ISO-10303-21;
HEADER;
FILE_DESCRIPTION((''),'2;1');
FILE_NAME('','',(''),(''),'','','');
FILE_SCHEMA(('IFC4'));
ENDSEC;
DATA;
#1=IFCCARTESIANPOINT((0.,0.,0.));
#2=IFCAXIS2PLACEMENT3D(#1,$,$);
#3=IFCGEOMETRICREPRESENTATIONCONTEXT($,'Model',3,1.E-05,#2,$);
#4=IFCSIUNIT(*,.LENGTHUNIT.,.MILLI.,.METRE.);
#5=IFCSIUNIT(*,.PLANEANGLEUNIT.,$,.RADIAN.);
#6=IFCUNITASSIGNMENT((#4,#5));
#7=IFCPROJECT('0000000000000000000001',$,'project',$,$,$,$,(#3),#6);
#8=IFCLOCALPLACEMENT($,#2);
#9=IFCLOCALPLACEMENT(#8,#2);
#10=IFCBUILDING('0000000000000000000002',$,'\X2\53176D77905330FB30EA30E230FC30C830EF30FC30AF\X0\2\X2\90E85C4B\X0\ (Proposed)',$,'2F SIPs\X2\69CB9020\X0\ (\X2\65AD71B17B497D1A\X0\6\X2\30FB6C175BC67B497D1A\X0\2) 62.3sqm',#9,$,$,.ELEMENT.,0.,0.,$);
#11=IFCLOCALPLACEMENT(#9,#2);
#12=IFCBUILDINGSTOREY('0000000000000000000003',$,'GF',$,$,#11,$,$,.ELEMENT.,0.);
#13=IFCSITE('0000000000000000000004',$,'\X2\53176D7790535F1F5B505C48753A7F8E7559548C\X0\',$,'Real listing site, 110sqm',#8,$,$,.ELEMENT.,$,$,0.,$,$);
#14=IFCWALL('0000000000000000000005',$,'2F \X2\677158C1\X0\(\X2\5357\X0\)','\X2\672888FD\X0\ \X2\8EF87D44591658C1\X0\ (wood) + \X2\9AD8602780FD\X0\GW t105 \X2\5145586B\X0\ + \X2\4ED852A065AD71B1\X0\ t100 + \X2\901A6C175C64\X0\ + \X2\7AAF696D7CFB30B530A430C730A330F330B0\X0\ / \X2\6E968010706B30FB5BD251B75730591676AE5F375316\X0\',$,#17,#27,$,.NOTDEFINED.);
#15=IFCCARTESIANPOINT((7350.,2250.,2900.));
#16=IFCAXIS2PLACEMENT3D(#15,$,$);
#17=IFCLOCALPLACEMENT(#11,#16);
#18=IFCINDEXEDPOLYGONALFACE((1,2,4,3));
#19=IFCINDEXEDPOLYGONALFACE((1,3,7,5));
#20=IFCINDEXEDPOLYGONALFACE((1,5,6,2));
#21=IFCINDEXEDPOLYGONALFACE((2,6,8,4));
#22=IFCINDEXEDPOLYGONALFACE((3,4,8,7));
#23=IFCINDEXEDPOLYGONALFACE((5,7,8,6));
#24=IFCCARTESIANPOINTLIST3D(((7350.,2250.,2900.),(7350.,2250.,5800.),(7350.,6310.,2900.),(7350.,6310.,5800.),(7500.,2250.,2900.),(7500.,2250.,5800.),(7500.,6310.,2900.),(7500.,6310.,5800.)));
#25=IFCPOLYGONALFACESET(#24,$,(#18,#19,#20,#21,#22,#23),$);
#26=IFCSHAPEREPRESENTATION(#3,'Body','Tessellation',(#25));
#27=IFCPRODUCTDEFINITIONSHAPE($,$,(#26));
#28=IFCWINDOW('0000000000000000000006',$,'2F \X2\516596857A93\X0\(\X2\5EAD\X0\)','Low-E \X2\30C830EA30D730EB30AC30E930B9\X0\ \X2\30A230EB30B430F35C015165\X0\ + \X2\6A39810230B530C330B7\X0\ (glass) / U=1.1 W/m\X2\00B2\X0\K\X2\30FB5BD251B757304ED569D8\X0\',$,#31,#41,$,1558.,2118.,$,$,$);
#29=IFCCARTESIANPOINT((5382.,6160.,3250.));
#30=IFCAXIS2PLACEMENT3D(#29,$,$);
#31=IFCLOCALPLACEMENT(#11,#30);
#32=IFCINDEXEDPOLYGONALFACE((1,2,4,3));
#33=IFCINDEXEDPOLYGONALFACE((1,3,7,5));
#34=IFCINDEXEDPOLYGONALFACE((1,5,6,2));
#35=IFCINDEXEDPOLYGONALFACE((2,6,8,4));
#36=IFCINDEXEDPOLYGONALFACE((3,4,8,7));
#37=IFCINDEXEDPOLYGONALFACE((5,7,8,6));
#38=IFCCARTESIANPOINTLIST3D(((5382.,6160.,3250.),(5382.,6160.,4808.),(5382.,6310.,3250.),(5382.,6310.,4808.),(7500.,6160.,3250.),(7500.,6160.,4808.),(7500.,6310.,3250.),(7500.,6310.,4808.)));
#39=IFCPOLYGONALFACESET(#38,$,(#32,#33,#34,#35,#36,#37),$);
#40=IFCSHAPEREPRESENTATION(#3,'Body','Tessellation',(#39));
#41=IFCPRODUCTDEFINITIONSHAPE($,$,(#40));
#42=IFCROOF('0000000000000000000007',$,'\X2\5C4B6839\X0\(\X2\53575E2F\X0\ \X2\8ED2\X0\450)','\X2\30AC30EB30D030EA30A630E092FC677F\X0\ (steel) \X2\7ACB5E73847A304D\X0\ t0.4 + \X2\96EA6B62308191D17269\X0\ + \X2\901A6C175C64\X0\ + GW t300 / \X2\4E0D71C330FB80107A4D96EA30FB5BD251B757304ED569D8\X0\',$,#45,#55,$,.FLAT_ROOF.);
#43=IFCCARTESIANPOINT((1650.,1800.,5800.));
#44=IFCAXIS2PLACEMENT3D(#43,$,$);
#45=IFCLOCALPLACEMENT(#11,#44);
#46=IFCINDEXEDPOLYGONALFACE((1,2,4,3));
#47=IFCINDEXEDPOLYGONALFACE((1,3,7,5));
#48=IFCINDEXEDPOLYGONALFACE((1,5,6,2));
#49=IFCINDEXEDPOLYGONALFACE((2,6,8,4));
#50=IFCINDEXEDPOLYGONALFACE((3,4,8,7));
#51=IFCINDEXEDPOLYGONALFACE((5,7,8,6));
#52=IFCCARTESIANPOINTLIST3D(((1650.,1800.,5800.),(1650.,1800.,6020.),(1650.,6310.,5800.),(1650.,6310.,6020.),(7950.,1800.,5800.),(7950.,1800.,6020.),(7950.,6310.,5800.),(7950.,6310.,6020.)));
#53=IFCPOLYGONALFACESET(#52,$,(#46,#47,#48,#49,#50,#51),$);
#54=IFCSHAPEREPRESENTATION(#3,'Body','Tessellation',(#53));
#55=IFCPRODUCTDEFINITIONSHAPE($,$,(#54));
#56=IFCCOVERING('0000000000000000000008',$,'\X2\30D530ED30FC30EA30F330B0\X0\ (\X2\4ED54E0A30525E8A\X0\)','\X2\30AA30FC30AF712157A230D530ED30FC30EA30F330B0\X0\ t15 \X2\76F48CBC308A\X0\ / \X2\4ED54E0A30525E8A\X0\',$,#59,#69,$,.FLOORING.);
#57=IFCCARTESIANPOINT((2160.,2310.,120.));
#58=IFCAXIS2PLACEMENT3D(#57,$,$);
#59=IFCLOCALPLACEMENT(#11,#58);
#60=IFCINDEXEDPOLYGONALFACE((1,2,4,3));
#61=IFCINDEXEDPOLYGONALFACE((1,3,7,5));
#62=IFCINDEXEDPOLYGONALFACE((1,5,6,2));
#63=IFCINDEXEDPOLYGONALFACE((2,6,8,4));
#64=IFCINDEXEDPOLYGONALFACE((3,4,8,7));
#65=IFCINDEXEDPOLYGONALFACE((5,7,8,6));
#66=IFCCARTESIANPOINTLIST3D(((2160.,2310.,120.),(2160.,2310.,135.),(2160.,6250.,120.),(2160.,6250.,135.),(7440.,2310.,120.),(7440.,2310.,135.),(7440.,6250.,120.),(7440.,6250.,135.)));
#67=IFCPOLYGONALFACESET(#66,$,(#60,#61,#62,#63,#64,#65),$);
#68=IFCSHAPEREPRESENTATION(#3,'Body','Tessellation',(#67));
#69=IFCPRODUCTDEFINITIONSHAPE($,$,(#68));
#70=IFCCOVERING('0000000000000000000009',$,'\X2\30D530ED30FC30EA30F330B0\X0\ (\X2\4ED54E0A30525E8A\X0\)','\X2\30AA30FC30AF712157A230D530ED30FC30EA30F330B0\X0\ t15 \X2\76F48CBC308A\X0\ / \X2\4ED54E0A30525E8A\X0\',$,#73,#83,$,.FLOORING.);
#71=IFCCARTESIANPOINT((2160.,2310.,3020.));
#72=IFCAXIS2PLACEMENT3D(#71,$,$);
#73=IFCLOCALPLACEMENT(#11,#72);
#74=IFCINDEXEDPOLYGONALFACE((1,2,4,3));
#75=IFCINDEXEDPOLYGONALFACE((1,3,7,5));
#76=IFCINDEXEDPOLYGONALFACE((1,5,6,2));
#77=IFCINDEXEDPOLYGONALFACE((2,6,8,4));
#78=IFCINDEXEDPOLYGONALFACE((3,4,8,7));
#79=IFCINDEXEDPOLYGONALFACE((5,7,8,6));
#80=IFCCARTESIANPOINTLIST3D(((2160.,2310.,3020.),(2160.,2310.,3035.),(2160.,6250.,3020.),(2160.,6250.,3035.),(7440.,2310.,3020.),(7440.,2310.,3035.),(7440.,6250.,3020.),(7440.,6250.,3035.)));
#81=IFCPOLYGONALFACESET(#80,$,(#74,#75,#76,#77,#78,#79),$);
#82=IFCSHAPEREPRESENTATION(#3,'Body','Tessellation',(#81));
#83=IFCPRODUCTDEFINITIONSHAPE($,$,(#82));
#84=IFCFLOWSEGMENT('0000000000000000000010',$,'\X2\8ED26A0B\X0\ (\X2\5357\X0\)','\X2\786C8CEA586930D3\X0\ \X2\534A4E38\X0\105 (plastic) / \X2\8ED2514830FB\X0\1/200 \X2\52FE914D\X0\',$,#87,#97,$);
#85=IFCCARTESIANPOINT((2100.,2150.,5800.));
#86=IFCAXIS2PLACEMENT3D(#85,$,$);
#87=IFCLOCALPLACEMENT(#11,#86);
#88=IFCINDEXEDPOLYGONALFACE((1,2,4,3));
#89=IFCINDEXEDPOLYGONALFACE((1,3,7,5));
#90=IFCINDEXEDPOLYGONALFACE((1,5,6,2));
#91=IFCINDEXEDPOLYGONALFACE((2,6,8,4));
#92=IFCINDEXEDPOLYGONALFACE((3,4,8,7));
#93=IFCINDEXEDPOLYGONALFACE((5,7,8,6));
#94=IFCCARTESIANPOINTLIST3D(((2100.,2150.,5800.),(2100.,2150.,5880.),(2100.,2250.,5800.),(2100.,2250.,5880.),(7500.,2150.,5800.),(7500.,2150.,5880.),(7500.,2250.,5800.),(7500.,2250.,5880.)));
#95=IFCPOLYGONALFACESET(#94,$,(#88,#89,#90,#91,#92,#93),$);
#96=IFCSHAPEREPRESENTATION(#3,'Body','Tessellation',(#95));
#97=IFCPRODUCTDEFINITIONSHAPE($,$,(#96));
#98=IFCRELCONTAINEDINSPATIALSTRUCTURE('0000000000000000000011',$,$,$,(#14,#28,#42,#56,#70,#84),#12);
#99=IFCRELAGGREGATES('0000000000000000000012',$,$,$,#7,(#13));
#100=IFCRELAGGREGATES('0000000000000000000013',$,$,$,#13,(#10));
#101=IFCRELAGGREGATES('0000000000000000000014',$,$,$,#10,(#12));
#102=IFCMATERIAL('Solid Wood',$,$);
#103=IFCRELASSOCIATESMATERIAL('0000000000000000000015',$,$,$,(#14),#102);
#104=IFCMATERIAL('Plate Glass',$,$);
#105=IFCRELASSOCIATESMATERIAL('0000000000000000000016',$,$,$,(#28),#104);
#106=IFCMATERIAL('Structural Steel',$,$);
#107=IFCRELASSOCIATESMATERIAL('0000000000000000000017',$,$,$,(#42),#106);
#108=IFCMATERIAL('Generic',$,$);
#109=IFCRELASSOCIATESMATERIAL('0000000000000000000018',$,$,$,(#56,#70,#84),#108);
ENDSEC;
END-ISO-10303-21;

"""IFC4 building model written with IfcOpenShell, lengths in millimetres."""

from ifc_helpers import new_model, si_unit, frame, frame_2d, origin, place, context, project, spatial, rectangle, extrude, material, element, fill, save


model = new_model("IFC4")

# Units and contexts
model_context = context("Model", 3, precision=1e-05, world=origin())
ifc_project = project(units=[si_unit("LENGTHUNIT", "METRE", prefix="MILLI"), si_unit("PLANEANGLEUNIT", "RADIAN")], contexts=[model_context])

# Site, building, storey
site_placement = place(None, origin())
site = spatial("IfcSite", under=ifc_project, at=site_placement, Name="北海道弟子屈町美留和", ObjectType="Real listing site, 110sqm", CompositionType="ELEMENT", RefElevation=0.0)
building_placement = place(site_placement, origin())
building = spatial("IfcBuilding", under=site, at=building_placement, Name="北海道・リモートワーク2部屋 (Proposed)", ObjectType="2F SIPs構造 (断熱等級6・気密等級2) 62.3sqm", CompositionType="ELEMENT", ElevationOfRefHeight=0.0, ElevationOfTerrain=0.0)
storey_placement = place(building_placement, origin())
storey = spatial("IfcBuildingStorey", under=building, at=storey_placement, Name="GF", CompositionType="ELEMENT", Elevation=0.0)

# Shared definitions
ifc_material_1 = material(Name="Solid Wood")

# Wall, opening, window
ifc_material_2 = material(Name="Plate Glass")
wall_1_placement = place(storey_placement, frame((7350.0, 2250.0, 2900.0)))
wall_1 = element("IfcWall", 1, at=wall_1_placement, inside=storey, material=ifc_material_1, Name="2F 東壁(南)", Description="木製 軸組外壁 (wood) + 高性能GW t105 充填 + 付加断熱 t100 + 通気層 + 窯業系サイディング / 準耐火・寒冷地外皮強化", PredefinedType="NOTDEFINED", context=model_context, shape_type="SweptSolid", body=[
    extrude(rectangle(XDim=150.0, YDim=4060.0, at=frame_2d((75.0, 2030.0))), frame((7350.0, 2250.0, 2900.0)), (0.0, 0.0, 1.0), 2900.0),
])
opening_1_placement = place(storey_placement, frame((5382.0, 6160.0, 3250.0)))
opening_1 = element("IfcOpeningElement", 2, at=opening_1_placement, cuts=wall_1, PredefinedType="NOTDEFINED", context=model_context, shape_type="SweptSolid", body=[
    extrude(rectangle(XDim=2118.0, YDim=150.0, at=frame_2d((1059.0, 75.0))), frame((5382.0, 6160.0, 3250.0)), (0.0, 0.0, 1.0), 1558.0),
])
window_1_placement = place(storey_placement, frame((5382.0, 6160.0, 3250.0)))
window_1 = element("IfcWindow", 3, at=window_1_placement, inside=storey, material=ifc_material_2, Name="2F 入隅窓(庭)", Description="Low-E トリプルガラス アルゴン封入 + 樹脂サッシ (glass) / U=1.1 W/m²K・寒冷地仕様", OverallHeight=1558.0, OverallWidth=2118.0, context=model_context, shape_type="SweptSolid", body=[
    extrude(rectangle(XDim=2118.0, YDim=150.0, at=frame_2d((1059.0, 75.0))), frame((5382.0, 6160.0, 3250.0)), (0.0, 0.0, 1.0), 1558.0),
])
fill(opening_1, window_1)

# Roof
ifc_material_3 = material(Name="Structural Steel")
for number, where, name in (
    (4, (1650.0, 1800.0, 5800.0), "屋根(南帯 軒450)"),
):
    element("IfcRoof", number, at=place(storey_placement, frame(where)), inside=storey, material=ifc_material_3, Name=name, Description="ガルバリウム鋼板 (steel) 立平葺き t0.4 + 雪止め金物 + 通気層 + GW t300 / 不燃・耐積雪・寒冷地仕様", PredefinedType="FLAT_ROOF", context=model_context, shape_type="SweptSolid", body=[
        extrude(rectangle(XDim=6300.0, YDim=4510.0, at=frame_2d((3150.0, 2255.0))), frame((1650.0, 1800.0, 5800.0)), (0.0, 0.0, 1.0), 220.0),
    ])

# Coverings
ifc_material_4 = material(Name="Generic")
covering_1_placement = place(storey_placement, frame((2160.0, 2310.0, 120.0)))
element("IfcCovering", 5, at=covering_1_placement, inside=storey, material=ifc_material_4, Name="フローリング (仕上げ床)", Description="オーク無垢フローリング t15 直貼り / 仕上げ床", PredefinedType="FLOORING", context=model_context, shape_type="SweptSolid", body=[
    extrude(rectangle(XDim=5280.0, YDim=3940.0, at=frame_2d((2640.0, 1970.0))), frame((2160.0, 2310.0, 120.0)), (0.0, 0.0, 1.0), 15.0),
])
covering_2_placement = place(storey_placement, frame((2160.0, 2310.0, 3020.0)))
element("IfcCovering", 6, at=covering_2_placement, inside=storey, material=ifc_material_4, Name="フローリング (仕上げ床)", Description="オーク無垢フローリング t15 直貼り / 仕上げ床", PredefinedType="FLOORING", context=model_context, shape_type="SweptSolid", body=[
    extrude(rectangle(XDim=5280.0, YDim=3940.0, at=frame_2d((2640.0, 1970.0))), frame((2160.0, 2310.0, 3020.0)), (0.0, 0.0, 1.0), 15.0),
])

# Flow segment
flow_segment_placement = place(storey_placement, frame((2100.0, 2150.0, 5800.0)))
element("IfcFlowSegment", 7, at=flow_segment_placement, inside=storey, material=ifc_material_4, Name="軒樋 (南)", Description="硬質塩ビ 半丸105 (plastic) / 軒先・1/200 勾配", context=model_context, shape_type="SweptSolid", body=[
    extrude(rectangle(XDim=5400.0, YDim=100.0, at=frame_2d((2700.0, 50.0))), frame((2100.0, 2150.0, 5800.0)), (0.0, 0.0, 1.0), 80.0),
])

save(model, "model.ifc")
